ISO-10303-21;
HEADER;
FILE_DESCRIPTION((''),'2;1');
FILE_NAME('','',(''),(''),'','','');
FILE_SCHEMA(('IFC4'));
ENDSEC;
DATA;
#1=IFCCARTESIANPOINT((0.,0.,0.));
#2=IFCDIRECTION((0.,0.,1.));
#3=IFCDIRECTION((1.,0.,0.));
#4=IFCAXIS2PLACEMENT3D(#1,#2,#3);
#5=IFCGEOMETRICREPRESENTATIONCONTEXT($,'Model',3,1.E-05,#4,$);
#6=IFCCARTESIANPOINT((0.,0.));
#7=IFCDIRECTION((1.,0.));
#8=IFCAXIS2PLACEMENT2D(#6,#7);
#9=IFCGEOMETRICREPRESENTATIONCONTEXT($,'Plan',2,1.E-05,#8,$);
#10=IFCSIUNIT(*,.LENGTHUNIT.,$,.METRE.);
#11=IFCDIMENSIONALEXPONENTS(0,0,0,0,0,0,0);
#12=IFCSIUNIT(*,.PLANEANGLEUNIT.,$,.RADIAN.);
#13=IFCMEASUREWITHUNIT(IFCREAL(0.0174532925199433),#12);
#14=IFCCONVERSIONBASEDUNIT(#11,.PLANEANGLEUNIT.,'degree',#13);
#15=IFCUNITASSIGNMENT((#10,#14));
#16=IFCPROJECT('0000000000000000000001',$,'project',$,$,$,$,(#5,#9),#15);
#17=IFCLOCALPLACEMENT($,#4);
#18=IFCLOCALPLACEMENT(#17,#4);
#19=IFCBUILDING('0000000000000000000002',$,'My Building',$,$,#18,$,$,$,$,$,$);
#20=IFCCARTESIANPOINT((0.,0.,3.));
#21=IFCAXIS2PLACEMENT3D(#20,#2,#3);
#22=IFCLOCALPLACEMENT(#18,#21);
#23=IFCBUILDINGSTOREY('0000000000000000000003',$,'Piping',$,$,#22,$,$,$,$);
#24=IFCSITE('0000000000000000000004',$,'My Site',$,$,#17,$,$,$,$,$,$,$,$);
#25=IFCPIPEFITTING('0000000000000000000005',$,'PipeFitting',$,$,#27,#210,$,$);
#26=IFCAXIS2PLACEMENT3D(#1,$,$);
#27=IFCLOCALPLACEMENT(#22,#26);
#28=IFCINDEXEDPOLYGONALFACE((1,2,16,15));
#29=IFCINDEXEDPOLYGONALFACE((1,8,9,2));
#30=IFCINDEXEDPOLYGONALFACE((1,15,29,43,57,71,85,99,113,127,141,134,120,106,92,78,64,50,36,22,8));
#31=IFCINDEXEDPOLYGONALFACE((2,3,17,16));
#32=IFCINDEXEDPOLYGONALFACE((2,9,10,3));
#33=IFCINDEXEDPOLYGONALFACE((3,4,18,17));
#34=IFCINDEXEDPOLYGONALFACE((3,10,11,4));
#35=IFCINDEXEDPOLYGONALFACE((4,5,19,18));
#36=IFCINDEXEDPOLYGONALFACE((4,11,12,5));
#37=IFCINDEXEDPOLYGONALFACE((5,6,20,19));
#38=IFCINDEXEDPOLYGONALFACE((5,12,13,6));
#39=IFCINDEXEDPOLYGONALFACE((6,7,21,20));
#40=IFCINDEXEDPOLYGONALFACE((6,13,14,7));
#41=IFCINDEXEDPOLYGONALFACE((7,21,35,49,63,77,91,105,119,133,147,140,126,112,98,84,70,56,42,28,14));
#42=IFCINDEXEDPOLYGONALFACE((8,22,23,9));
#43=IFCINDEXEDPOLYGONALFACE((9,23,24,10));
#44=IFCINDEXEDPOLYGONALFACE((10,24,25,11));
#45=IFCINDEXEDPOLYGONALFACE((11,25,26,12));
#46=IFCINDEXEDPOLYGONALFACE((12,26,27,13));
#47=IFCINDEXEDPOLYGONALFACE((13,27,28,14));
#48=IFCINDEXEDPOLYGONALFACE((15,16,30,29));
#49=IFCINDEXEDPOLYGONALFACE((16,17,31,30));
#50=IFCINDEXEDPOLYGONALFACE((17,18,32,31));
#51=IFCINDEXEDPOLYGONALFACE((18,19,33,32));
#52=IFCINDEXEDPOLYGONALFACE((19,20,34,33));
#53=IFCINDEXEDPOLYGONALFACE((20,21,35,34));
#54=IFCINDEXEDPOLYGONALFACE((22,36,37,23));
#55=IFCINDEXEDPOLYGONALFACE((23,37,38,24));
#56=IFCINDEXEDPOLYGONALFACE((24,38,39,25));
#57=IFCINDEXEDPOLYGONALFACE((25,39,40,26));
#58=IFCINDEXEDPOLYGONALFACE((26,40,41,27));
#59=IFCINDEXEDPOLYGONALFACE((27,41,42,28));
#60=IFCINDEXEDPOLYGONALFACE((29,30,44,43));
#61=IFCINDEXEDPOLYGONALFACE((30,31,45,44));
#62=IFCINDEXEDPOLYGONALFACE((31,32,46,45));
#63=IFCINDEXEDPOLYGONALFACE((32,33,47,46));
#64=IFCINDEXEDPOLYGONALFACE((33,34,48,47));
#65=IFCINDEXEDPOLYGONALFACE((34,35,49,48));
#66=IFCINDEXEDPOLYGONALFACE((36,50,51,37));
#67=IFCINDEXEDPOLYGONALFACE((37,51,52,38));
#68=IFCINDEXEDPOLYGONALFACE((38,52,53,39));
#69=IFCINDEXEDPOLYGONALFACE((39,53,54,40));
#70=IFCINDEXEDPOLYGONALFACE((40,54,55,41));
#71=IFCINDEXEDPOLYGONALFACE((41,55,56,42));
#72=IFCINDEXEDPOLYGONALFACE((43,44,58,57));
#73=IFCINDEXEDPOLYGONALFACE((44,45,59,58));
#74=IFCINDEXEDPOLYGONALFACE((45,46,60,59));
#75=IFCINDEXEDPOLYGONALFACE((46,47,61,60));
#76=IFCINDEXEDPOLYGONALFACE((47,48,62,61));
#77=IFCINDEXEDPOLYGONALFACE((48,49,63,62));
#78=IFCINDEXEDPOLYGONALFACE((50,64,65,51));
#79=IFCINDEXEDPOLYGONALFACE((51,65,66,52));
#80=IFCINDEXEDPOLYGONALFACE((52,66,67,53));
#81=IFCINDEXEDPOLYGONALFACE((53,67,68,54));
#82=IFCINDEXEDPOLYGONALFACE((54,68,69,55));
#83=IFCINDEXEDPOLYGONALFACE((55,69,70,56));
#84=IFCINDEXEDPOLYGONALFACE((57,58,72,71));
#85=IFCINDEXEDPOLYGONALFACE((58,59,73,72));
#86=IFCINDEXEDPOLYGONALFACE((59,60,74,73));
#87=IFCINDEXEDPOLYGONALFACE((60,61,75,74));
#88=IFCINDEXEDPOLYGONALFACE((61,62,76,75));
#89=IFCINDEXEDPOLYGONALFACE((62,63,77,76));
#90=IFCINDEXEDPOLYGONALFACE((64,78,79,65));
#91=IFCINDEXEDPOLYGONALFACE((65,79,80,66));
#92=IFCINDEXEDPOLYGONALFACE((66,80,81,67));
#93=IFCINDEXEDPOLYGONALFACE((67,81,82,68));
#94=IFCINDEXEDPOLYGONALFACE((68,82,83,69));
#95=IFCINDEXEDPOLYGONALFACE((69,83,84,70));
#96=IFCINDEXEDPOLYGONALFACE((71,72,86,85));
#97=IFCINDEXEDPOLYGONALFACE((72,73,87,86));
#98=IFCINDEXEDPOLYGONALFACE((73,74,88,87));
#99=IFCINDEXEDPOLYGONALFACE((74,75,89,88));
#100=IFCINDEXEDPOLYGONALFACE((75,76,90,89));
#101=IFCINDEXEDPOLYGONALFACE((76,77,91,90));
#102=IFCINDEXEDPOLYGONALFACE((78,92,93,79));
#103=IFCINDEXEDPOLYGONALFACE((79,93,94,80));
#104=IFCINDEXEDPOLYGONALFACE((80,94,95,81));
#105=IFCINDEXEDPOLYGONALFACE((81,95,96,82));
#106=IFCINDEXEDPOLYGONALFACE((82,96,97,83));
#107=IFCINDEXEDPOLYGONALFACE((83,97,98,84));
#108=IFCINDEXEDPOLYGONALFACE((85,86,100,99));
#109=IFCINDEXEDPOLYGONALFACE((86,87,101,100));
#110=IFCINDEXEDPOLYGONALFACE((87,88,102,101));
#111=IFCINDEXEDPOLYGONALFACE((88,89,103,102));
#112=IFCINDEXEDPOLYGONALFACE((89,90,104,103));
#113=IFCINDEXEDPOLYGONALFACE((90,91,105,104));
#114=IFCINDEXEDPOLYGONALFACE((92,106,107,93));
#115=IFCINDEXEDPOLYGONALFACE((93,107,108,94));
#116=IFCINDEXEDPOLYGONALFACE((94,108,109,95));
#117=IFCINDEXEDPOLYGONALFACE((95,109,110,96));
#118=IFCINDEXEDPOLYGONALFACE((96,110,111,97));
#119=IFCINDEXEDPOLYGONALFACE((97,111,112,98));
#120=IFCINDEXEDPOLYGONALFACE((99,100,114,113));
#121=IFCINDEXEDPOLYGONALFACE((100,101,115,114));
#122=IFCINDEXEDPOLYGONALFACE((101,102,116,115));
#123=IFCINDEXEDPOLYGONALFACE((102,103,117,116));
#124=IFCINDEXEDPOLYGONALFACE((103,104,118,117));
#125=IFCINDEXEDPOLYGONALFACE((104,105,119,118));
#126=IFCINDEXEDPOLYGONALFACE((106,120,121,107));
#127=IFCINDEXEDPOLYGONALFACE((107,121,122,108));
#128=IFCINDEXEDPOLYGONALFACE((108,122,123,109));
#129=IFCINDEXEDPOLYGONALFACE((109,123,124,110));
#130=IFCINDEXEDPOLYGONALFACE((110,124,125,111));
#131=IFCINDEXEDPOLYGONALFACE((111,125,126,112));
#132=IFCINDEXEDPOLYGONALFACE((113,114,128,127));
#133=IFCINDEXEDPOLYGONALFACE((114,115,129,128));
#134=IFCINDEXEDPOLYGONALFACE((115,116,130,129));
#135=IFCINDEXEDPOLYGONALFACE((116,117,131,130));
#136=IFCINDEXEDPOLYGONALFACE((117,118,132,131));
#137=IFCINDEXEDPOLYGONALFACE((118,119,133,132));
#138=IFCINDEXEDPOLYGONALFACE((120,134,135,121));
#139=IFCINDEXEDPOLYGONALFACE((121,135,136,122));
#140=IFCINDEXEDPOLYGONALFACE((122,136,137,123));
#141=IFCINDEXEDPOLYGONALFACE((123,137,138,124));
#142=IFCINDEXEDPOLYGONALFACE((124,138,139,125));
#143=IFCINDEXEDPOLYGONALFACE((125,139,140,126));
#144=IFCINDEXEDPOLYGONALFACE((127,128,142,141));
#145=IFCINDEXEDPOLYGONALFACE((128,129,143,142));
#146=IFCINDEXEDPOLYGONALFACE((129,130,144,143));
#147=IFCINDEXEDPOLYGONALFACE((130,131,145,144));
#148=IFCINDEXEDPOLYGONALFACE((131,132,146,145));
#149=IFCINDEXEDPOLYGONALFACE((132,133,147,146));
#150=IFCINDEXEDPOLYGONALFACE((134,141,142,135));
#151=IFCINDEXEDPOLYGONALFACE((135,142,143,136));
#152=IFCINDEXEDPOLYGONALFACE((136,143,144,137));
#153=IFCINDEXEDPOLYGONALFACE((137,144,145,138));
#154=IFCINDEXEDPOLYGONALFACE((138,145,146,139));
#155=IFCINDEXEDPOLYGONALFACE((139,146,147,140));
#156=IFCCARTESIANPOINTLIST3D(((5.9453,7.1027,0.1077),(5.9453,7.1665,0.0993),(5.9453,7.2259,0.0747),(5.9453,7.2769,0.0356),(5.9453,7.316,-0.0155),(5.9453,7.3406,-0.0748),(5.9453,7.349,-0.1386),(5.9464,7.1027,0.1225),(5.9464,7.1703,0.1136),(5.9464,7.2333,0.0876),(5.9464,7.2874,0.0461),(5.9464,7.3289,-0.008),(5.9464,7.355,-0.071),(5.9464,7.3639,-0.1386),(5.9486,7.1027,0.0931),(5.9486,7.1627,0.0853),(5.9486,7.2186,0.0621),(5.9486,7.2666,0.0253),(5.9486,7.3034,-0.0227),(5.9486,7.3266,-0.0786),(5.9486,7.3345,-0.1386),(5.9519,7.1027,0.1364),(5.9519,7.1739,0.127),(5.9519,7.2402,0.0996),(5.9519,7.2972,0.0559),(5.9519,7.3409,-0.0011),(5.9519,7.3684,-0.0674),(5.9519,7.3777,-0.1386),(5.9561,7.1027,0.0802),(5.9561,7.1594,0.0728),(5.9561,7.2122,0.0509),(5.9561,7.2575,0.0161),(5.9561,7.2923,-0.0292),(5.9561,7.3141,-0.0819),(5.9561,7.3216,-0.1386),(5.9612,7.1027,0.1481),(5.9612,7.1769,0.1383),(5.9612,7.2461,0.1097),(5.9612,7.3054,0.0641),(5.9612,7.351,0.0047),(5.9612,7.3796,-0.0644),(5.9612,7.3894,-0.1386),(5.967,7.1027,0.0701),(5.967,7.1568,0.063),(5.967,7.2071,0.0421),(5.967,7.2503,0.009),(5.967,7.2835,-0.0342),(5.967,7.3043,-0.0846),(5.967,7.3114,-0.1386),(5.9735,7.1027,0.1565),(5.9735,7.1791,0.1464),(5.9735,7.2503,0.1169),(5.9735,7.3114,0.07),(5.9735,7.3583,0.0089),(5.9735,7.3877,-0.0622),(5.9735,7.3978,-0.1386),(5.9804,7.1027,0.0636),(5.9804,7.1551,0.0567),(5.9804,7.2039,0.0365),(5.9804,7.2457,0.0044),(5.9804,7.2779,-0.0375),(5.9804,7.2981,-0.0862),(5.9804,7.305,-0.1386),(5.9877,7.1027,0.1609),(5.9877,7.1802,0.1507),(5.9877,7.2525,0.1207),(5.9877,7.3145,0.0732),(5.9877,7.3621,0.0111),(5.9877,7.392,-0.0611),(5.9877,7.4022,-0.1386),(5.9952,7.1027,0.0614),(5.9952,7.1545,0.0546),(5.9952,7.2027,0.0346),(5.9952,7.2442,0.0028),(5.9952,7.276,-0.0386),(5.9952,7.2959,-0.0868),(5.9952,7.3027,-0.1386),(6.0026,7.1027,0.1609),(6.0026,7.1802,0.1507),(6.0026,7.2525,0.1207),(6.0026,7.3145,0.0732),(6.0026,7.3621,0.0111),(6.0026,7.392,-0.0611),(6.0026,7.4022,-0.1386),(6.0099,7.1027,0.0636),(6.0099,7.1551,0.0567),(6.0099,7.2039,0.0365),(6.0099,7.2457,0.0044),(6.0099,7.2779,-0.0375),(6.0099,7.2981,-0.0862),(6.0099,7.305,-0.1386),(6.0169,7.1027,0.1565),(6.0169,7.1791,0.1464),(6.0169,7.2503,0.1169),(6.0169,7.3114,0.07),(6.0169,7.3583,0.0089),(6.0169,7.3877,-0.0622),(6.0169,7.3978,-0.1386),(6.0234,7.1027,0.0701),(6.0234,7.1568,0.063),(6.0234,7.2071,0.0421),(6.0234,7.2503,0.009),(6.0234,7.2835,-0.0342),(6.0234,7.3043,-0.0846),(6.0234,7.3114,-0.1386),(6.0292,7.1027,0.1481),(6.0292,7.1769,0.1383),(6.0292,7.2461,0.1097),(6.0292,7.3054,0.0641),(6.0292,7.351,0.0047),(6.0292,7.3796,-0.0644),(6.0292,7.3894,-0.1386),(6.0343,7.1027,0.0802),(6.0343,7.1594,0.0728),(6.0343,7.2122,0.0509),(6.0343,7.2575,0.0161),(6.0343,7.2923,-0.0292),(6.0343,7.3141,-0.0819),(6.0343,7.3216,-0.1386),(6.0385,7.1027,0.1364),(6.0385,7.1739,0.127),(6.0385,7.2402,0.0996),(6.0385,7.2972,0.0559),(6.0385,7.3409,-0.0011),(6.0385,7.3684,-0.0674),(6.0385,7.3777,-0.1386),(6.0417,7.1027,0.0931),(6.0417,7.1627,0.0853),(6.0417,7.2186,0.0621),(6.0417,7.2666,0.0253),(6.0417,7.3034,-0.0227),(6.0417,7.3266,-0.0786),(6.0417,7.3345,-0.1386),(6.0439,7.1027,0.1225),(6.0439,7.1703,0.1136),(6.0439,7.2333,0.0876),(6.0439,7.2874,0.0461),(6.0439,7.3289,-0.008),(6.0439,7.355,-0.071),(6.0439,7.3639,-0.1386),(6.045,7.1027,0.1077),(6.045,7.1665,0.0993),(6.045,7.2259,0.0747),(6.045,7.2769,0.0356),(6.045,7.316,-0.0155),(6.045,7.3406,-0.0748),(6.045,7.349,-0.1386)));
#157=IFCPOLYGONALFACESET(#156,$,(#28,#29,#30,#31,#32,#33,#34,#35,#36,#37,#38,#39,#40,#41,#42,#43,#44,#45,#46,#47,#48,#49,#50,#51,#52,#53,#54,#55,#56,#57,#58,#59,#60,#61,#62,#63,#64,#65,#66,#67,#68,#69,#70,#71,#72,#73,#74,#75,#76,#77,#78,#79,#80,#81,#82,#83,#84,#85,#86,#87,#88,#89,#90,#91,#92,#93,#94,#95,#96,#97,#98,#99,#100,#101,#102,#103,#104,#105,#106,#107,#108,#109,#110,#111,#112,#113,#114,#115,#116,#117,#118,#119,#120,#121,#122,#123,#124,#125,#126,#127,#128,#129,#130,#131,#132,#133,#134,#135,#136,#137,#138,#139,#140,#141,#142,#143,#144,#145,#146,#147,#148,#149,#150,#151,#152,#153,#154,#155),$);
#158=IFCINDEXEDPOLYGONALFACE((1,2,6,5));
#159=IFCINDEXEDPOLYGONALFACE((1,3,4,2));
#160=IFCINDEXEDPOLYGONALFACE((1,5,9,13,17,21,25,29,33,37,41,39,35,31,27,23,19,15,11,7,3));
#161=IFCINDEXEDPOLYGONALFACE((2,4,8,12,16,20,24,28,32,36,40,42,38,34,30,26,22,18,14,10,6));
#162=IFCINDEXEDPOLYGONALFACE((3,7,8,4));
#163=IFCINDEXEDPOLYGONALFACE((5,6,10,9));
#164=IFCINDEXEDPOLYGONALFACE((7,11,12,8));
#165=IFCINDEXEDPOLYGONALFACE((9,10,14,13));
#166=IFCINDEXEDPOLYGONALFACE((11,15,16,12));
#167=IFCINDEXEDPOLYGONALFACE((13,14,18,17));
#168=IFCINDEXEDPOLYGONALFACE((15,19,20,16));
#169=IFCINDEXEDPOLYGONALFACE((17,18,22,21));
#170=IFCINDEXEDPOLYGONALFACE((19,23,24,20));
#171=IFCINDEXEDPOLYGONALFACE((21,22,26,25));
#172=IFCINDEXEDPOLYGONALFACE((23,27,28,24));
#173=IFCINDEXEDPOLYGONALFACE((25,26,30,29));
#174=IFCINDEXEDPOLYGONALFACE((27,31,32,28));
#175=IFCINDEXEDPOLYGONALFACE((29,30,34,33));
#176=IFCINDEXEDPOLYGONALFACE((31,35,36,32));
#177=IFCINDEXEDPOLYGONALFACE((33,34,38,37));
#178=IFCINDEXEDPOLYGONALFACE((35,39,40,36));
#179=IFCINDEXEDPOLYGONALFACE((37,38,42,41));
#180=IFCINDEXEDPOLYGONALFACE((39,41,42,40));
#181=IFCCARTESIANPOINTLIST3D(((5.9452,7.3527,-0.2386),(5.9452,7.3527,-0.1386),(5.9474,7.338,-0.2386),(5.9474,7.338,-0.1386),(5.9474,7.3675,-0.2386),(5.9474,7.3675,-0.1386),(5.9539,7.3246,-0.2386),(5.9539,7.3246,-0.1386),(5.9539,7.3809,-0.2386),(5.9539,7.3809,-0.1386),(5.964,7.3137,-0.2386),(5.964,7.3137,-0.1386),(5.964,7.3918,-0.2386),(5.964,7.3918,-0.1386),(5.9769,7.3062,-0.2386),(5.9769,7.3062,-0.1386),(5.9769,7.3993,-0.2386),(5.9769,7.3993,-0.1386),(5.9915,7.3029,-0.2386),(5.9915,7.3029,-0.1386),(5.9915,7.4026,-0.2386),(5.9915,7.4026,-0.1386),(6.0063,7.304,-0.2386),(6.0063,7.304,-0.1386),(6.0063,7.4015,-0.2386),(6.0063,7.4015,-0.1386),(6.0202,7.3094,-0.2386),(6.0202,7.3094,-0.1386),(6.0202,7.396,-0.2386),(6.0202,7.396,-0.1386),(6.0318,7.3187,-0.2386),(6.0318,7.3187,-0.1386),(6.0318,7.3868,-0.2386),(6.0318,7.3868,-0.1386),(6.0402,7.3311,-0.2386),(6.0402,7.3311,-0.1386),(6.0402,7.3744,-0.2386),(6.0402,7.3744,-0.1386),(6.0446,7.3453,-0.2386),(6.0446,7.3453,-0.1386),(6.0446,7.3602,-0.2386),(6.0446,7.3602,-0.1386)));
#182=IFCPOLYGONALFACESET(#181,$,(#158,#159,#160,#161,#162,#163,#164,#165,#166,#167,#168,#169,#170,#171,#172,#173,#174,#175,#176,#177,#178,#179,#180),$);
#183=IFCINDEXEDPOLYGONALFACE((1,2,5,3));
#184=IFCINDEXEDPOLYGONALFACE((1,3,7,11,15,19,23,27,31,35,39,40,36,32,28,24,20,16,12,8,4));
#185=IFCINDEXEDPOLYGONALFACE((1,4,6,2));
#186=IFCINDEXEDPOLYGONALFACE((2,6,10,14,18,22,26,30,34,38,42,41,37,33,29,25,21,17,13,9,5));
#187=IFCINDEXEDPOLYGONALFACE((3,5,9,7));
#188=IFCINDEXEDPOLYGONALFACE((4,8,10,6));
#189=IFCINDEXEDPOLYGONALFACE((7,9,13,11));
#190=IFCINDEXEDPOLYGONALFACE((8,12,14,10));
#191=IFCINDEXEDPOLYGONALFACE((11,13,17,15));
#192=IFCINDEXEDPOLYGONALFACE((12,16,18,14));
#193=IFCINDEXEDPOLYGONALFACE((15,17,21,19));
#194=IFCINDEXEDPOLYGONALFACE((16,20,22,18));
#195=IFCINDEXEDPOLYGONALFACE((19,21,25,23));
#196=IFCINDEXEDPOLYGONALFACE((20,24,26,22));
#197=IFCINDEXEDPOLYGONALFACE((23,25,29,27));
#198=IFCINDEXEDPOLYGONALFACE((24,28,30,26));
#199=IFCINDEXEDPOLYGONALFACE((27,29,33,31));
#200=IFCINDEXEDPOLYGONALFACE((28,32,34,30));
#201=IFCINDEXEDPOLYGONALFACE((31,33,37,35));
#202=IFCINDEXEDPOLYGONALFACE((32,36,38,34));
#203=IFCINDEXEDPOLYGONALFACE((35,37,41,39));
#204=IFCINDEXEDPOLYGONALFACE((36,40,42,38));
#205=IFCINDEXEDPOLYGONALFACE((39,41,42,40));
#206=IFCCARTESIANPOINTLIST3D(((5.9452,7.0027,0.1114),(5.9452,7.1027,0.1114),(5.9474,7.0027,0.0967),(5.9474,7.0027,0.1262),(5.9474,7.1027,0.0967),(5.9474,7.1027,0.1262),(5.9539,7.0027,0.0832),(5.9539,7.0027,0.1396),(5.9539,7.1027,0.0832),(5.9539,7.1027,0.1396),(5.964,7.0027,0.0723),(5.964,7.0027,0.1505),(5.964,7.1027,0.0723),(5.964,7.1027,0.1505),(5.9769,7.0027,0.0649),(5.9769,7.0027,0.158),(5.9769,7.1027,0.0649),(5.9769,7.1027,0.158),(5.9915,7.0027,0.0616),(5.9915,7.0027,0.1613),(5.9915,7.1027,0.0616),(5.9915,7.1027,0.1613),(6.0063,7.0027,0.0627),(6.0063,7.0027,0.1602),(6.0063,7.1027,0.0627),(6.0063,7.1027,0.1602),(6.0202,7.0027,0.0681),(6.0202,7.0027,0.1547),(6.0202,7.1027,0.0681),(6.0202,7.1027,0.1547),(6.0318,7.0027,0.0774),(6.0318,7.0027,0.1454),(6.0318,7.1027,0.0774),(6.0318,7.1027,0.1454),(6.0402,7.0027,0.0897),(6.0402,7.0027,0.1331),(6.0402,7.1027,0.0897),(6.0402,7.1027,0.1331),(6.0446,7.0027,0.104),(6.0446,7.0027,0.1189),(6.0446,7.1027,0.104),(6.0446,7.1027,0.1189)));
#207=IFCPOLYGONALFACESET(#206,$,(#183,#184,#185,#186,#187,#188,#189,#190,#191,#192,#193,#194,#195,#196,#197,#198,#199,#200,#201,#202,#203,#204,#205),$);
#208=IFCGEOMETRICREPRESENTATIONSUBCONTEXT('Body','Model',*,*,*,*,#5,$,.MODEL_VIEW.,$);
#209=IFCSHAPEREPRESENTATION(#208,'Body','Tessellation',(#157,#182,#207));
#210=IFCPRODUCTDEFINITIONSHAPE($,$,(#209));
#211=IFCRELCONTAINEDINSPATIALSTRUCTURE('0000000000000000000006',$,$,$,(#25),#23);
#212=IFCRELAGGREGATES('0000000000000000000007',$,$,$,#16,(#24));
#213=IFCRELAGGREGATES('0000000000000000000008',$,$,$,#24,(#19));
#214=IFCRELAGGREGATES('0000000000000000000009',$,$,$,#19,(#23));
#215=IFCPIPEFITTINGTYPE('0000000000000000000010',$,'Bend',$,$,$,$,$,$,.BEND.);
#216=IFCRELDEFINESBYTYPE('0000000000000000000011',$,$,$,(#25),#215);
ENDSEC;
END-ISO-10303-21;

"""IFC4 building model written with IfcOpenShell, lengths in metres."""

from ifc_helpers import new_model, entity, si_unit, converted_unit, frame, origin_with_axes, origin_2d_with_axis, place, context, subcontext, project, spatial, circle, extrude, source, transform, mapped, type_object, type_shapes, element, save


model = new_model("IFC4")

# Units and contexts
model_context = context("Model", 3, precision=1e-05, world=origin_with_axes())
plan_context = context("Plan", 2, precision=1e-05, world=origin_2d_with_axis())
body_context = subcontext(model_context, "Body", "Model", "MODEL_VIEW")
ifc_project = project(units=[si_unit("LENGTHUNIT", "METRE"), converted_unit("PLANEANGLEUNIT", "degree", entity("IfcReal", 0.0174532925199433), si_unit("PLANEANGLEUNIT", "RADIAN"), dimensions=[0, 0, 0, 0, 0, 0, 0])], contexts=[model_context, plan_context])

# Site, building, storey
site_placement = place(None, origin_with_axes())
site = spatial("IfcSite", under=ifc_project, at=site_placement, Name="My Site")
building_placement = place(site_placement, origin_with_axes())
building = spatial("IfcBuilding", under=site, at=building_placement, Name="My Building")
storey_placement = place(building_placement, frame((0.0, 0.0, 3.0), z_axis=(0.0, 0.0, 1.0), x_axis=(1.0, 0.0, 0.0)))
storey = spatial("IfcBuildingStorey", under=building, at=storey_placement, Name="Piping")

# Pipe fitting
pipe_fitting_type_1 = type_object("IfcPipeFittingType", Name="Bend", PredefinedType="BEND")
shared_shape = source(origin_with_axes(), body_context, "Body", "SolidModel", [
    entity("IfcSweptDiskSolid", entity("IfcIndexedPolyCurve", entity("IfcCartesianPointList3D", [[0.0, 0.0, -0.1], [0.0, -0.0732, -0.2768], [0.0, -0.25, -0.35]]), [entity("IfcArcIndex", [1, 2, 3])]), 0.05),
    extrude(circle(Radius=0.05), origin_with_axes(), (0.0, 0.0, -1.0), 0.1),
    extrude(circle(Radius=0.05), frame((0.0, -0.25, -0.35), z_axis=(0.0, -1.0, 0.0), x_axis=(1.0, 0.0, 0.0)), (0.0, 0.0, 1.0), 0.1),
])
type_shapes(pipe_fitting_type_1, [shared_shape])
for number, where, z_axis, x_axis, name in (
    (1, (5.9952, 7.3527, -0.2386), (0.0, 0.0, -1.0), (-1.0, 0.0, 0.0), "PipeFitting"),
):
    element("IfcPipeFitting", number, at=place(storey_placement, frame(where, z_axis=z_axis, x_axis=x_axis)), inside=storey, type_object=pipe_fitting_type_1, Name=name, context=body_context, shape_type="MappedRepresentation", body=[
        mapped(shared_shape, transform((0.0, 0.0, 0.0), x_axis=(1.0, 0.0, 0.0), y_axis=(0.0, 1.0, 0.0), z_axis=(0.0, 0.0, 1.0), scale=1.0)),
    ])

save(model, "model.ifc")
